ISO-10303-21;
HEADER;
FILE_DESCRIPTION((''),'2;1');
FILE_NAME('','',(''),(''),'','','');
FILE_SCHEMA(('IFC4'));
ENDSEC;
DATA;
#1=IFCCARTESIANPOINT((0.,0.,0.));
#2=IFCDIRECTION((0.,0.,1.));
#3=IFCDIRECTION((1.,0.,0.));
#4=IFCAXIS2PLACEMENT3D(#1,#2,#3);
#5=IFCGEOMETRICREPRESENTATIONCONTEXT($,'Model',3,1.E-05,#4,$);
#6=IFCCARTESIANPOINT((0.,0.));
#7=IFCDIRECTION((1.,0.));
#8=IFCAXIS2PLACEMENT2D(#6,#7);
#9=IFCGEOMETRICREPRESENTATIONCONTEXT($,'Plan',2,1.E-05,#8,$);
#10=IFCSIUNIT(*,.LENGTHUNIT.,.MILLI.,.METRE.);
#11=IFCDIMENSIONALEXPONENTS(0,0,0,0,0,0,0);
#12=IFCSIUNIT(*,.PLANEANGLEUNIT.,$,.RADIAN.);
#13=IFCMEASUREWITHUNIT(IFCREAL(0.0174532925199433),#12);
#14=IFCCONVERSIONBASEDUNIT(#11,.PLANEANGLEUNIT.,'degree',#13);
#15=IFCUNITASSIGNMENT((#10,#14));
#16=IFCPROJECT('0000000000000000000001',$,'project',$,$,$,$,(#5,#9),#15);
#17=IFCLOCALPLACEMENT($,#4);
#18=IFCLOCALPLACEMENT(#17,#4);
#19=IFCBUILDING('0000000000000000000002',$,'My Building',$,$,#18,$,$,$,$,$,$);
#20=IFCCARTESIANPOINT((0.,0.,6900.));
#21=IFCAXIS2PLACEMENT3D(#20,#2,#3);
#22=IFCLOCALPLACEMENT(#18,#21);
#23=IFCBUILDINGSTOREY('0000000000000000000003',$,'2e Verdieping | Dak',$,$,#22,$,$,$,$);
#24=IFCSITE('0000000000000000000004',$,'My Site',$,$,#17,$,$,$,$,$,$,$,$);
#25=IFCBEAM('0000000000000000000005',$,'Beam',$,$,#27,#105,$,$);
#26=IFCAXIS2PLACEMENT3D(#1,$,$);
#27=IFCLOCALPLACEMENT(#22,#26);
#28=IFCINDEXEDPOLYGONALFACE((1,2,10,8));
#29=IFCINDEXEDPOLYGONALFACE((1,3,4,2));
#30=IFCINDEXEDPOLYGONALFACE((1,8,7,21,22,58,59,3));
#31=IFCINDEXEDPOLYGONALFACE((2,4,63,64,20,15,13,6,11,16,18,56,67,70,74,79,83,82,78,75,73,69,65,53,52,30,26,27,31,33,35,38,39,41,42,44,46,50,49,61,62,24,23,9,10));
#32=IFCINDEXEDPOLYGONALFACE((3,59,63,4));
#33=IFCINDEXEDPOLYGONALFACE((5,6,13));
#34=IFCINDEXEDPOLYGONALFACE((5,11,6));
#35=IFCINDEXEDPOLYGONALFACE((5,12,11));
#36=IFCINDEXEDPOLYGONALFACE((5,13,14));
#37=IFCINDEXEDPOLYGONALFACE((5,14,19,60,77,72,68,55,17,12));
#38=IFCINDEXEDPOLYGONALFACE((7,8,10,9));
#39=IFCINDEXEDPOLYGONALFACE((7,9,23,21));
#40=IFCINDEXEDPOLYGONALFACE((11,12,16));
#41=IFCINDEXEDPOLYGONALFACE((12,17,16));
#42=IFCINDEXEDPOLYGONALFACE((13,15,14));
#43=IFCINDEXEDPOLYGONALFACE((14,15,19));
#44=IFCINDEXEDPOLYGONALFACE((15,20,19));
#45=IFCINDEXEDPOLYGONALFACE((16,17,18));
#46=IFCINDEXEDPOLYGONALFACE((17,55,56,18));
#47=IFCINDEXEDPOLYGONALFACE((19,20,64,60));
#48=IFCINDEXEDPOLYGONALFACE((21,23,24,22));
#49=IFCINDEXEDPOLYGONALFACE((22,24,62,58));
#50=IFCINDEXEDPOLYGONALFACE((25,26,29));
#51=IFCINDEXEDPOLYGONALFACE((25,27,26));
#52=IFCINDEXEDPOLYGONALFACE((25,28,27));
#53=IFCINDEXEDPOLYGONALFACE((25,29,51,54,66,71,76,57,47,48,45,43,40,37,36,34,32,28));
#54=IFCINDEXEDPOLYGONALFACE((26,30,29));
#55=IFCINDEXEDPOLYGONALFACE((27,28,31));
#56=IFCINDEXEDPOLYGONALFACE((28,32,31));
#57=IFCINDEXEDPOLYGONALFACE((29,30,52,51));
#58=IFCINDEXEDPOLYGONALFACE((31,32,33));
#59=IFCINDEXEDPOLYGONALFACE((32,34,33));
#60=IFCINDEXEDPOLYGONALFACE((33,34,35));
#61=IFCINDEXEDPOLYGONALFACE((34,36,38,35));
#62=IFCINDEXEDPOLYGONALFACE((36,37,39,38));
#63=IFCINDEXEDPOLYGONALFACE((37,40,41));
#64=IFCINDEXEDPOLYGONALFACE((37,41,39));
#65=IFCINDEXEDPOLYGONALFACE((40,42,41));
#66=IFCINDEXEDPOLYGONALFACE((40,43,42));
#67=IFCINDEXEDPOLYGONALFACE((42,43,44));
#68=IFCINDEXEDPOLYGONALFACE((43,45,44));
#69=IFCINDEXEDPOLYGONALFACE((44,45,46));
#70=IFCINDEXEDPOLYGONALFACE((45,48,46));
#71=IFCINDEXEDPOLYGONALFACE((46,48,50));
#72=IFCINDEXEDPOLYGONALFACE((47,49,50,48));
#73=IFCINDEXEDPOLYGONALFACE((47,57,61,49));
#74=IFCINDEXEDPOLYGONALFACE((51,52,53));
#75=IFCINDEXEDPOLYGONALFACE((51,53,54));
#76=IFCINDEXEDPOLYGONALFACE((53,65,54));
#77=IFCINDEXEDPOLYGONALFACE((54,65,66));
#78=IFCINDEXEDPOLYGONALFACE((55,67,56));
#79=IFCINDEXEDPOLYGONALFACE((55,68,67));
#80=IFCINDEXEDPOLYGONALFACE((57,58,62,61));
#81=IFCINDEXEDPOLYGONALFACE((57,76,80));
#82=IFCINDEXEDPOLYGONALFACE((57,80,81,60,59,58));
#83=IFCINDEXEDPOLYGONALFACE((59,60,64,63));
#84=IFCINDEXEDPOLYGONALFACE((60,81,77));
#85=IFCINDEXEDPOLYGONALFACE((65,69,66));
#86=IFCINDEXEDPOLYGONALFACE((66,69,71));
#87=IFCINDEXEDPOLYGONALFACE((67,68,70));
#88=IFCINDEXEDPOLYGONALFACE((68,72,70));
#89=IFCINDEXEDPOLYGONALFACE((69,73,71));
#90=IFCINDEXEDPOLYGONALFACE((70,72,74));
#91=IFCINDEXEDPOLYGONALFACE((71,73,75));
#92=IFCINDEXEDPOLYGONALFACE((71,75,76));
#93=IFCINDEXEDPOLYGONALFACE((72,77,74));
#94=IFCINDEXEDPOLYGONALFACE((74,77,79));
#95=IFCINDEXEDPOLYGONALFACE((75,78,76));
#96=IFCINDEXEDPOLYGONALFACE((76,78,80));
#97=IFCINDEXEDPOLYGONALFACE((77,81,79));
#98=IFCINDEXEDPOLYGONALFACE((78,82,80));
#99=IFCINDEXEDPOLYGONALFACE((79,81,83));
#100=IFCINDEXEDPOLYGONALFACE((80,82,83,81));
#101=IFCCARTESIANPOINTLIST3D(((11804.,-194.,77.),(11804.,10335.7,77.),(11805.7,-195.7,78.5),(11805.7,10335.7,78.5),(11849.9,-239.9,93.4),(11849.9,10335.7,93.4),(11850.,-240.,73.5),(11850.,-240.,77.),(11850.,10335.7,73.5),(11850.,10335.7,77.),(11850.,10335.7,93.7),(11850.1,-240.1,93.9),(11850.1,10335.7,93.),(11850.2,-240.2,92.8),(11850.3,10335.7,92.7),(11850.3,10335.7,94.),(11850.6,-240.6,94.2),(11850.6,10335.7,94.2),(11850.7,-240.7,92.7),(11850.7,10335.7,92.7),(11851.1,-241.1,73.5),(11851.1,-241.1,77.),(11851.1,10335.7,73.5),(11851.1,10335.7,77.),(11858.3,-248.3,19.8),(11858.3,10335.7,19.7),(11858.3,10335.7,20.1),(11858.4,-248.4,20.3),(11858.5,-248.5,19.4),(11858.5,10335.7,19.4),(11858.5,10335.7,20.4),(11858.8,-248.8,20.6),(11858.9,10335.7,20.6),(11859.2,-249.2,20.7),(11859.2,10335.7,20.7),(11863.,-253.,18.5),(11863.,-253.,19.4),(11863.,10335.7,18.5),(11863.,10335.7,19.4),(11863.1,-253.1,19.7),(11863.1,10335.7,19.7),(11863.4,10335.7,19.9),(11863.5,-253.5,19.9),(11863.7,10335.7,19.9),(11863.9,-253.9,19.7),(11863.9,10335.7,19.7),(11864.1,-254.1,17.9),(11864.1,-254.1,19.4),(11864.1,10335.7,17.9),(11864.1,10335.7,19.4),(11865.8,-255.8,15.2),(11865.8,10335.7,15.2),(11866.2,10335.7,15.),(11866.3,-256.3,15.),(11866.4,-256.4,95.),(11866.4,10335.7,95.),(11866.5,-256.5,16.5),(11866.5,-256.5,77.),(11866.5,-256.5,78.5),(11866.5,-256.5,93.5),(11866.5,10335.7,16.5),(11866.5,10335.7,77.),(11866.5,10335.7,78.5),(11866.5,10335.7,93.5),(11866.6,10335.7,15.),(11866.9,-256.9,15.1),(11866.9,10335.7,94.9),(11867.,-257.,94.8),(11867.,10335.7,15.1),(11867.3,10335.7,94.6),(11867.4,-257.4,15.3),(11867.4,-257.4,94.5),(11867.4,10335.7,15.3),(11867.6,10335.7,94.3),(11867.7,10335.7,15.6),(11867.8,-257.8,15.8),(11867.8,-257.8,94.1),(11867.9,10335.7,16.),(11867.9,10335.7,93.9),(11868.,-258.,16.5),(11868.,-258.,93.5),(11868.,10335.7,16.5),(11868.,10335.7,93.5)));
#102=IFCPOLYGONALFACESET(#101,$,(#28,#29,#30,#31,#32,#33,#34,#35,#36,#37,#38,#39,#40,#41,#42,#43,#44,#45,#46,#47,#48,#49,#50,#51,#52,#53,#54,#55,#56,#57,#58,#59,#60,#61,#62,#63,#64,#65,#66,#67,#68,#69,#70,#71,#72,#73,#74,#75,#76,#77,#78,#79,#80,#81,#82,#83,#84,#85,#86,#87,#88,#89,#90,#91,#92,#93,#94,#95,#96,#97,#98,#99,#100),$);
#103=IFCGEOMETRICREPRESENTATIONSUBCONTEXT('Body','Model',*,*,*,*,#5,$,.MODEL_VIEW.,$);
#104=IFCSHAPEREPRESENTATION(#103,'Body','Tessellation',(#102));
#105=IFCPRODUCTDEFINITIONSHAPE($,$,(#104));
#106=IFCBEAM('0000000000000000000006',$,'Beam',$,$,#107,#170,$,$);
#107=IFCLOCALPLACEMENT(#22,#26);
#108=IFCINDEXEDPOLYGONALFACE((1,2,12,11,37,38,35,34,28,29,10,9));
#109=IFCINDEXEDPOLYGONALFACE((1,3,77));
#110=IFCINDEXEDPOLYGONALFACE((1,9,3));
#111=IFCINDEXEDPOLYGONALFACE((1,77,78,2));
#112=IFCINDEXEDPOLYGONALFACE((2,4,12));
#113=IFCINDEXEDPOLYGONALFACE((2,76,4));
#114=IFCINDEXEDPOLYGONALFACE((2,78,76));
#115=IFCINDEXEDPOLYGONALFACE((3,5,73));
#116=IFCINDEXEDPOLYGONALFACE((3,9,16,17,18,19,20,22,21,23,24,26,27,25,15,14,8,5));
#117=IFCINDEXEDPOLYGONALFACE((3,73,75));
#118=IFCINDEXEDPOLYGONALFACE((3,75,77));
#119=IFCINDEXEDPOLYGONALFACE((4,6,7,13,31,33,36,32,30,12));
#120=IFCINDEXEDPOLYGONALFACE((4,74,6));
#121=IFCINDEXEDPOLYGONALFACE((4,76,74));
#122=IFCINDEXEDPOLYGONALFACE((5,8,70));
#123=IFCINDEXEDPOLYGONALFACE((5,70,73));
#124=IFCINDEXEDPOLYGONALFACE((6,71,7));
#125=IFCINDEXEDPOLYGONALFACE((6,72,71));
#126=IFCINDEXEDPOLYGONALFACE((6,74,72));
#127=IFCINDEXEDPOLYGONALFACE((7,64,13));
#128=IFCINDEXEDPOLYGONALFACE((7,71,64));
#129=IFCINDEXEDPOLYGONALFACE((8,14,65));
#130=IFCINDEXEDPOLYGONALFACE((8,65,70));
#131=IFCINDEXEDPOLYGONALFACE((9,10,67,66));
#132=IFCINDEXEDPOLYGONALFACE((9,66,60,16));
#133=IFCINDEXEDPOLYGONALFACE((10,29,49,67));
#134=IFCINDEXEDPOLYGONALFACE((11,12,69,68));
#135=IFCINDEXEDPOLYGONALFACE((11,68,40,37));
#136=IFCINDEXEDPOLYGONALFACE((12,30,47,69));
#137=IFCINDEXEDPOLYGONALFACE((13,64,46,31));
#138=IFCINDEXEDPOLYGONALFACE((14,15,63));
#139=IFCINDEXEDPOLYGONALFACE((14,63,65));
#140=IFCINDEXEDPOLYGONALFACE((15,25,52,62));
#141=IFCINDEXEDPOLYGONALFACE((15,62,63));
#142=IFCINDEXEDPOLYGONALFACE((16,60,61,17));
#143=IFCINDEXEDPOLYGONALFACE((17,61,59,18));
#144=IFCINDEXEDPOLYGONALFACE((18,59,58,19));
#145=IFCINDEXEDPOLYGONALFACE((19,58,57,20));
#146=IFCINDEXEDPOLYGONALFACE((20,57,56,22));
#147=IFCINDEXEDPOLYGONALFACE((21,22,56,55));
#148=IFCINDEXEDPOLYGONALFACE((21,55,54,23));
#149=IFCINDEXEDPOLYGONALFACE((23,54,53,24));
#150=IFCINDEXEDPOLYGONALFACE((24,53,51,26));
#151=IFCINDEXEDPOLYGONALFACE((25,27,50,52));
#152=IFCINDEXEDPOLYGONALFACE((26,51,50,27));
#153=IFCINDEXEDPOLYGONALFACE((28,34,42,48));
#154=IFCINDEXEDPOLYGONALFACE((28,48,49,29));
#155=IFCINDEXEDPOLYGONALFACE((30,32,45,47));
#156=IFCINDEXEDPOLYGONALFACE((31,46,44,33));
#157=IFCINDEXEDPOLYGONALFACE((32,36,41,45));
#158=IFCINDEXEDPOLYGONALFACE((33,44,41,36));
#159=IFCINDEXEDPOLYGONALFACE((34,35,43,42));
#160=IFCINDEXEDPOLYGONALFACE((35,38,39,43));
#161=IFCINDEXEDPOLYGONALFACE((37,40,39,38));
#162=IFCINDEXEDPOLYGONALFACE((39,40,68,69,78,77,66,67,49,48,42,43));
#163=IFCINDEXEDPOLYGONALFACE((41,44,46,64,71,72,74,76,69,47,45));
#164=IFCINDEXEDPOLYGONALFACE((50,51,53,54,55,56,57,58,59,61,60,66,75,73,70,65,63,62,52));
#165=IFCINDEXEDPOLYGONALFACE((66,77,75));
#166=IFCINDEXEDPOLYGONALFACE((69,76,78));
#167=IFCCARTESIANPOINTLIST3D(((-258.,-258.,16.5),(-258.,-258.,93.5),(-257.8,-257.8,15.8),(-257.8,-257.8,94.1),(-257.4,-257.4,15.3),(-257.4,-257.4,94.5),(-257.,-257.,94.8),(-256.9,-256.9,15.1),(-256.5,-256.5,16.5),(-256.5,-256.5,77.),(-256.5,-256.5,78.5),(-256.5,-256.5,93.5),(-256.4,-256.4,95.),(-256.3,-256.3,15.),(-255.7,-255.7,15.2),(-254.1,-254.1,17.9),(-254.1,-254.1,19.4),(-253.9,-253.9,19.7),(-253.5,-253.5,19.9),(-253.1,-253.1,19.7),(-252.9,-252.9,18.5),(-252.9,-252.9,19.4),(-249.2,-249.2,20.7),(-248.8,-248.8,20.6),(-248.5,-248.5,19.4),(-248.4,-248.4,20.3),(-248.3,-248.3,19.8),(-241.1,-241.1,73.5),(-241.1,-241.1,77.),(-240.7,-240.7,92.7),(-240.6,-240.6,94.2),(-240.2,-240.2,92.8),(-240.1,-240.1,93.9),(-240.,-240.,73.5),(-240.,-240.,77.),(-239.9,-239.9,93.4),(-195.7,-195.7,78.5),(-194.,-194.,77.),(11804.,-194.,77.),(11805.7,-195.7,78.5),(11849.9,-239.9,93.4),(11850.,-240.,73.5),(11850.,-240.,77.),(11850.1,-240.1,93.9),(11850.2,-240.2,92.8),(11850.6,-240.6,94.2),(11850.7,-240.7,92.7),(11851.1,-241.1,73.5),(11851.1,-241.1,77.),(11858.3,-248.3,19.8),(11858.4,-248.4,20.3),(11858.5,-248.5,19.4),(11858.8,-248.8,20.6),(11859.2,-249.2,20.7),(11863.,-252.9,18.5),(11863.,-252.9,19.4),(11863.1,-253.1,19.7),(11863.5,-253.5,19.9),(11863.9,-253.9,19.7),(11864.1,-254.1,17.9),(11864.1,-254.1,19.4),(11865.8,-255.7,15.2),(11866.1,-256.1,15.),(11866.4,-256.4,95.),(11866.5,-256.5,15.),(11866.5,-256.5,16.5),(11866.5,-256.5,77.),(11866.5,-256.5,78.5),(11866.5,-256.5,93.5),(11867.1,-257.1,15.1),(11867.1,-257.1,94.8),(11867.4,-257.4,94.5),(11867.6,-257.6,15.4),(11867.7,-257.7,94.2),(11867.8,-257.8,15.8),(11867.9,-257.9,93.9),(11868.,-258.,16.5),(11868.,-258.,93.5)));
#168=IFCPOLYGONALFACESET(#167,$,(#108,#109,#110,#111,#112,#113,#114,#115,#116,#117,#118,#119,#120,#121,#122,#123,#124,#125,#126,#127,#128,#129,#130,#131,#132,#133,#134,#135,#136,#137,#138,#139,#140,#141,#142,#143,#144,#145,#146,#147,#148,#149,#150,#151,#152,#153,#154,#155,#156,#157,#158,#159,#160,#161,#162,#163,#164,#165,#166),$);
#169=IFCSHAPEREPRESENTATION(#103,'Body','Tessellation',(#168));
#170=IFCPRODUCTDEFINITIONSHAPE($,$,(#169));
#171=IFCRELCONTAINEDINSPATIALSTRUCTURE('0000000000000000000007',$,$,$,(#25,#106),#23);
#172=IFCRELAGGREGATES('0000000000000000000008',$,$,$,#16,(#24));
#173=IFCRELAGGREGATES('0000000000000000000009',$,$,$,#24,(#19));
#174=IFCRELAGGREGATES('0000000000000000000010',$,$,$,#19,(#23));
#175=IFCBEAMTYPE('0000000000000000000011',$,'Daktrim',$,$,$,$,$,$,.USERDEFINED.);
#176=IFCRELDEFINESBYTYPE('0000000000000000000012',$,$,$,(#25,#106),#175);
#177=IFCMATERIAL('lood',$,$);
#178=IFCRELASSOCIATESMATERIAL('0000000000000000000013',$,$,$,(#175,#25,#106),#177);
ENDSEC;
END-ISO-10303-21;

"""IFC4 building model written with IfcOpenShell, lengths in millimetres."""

from ifc_helpers import new_model, entity, si_unit, converted_unit, frame, origin_with_axes, origin_2d_with_axis, place, context, subcontext, project, spatial, line, arc, indexed_curve, outline, extrude, clip, halfspace, material, material_profile, profile_set, profile_usage, type_object, element, save


model = new_model("IFC4")

# Units and contexts
model_context = context("Model", 3, precision=1e-05, world=origin_with_axes())
plan_context = context("Plan", 2, precision=1e-05, world=origin_2d_with_axis())
body_context = subcontext(model_context, "Body", "Model", "MODEL_VIEW")
ifc_project = project(units=[si_unit("LENGTHUNIT", "METRE", prefix="MILLI"), converted_unit("PLANEANGLEUNIT", "degree", entity("IfcReal", 0.0174532925199433), si_unit("PLANEANGLEUNIT", "RADIAN"), dimensions=[0, 0, 0, 0, 0, 0, 0])], contexts=[model_context, plan_context])

# Site, building, storey
site_placement = place(None, origin_with_axes())
site = spatial("IfcSite", under=ifc_project, at=site_placement, Name="My Site")
building_placement = place(site_placement, origin_with_axes())
building = spatial("IfcBuilding", under=site, at=building_placement, Name="My Building")
storey_placement = place(building_placement, frame((0.0, 0.0, 6900.0), z_axis=(0.0, 0.0, 1.0), x_axis=(1.0, 0.0, 0.0)))
storey = spatial("IfcBuildingStorey", under=building, at=storey_placement, Name="2e Verdieping | Dak")

# Beams
ifc_material_1 = material(Name="lood")
ifc_material_profile_1 = material_profile(ifc_material_1, outline(indexed_curve([(12.9, -58.5), (12.9, -57.6), (13.5, -57.1), (14.1, -57.6), (14.1, -59.1), (16.5, -60.5), (16.5, 0.0), (1.1, 0.0), (1.1, -3.5), (0.0, -3.5), (0.0, 0.0), (-46.0, 0.0), (-44.3, 1.5), (16.5, 1.5), (16.5, 16.5), (0.7, 15.7), (-0.1, 16.4), (0.6, 17.2), (16.4, 18.0), (17.6, 17.3), (18.0, 16.5), (18.0, -60.5), (17.2, -61.8), (15.8, -61.8), (8.5, -57.6), (8.4, -56.7), (9.2, -56.3)], segments=[line(10, 9), line(9, 8), line(8, 7), line(7, 6), line(6, 5), line(5, 4), arc(4, 3, 2), line(2, 1), line(1, 27), arc(27, 26, 25), line(25, 24), arc(24, 23, 22), line(22, 21), arc(21, 20, 19), line(19, 18), arc(18, 17, 16), line(16, 15), line(15, 14), line(14, 13), line(13, 12), line(12, 11), line(11, 10)], self_intersect=False)))
ifc_profile_set_1 = profile_set([ifc_material_profile_1], Name="lood")
ifc_profile_usage_1 = profile_usage(ifc_profile_set_1, cardinal=5)
beam_type_1 = type_object("IfcBeamType", Name="Daktrim", PredefinedType="USERDEFINED", material=ifc_profile_set_1)
beam_1_placement = place(storey_placement, frame((11850.0, 10335.7, 77.0), z_axis=(0.0, -1.0, 0.0), x_axis=(1.0, 0.0, 0.0)))
element("IfcBeam", 1, at=beam_1_placement, inside=storey, type_object=beam_type_1, material=ifc_profile_usage_1, Name="Beam", context=body_context, shape_type="Clipping", body=[
    clip(extrude(outline(indexed_curve([(12.9, -58.5), (12.9, -57.6), (13.5, -57.1), (14.1, -57.6), (14.1, -59.1), (16.5, -60.5), (16.5, 0.0), (1.1, 0.0), (1.1, -3.5), (0.0, -3.5), (0.0, 0.0), (-46.0, 0.0), (-44.3, 1.5), (16.5, 1.5), (16.5, 16.5), (0.7, 15.7), (-0.1, 16.4), (0.6, 17.2), (16.4, 18.0), (17.6, 17.3), (18.0, 16.5), (18.0, -60.5), (17.2, -61.8), (15.8, -61.8), (8.5, -57.6), (8.4, -56.7), (9.2, -56.3)], segments=[line(10, 9), line(9, 8), line(8, 7), line(7, 6), line(6, 5), line(5, 4), arc(4, 3, 2), line(2, 1), line(1, 27), arc(27, 26, 25), line(25, 24), arc(24, 23, 22), line(22, 21), arc(21, 20, 19), line(19, 18), arc(18, 17, 16), line(16, 15), line(15, 14), line(14, 13), line(13, 12), line(12, 11), line(11, 10)], self_intersect=False)), origin_with_axes(), (0.0, 0.0, 1.0), 10593.7), halfspace(frame((18.0, -6977.0, 10593.7), z_axis=(-0.707106, 0.0, 0.707107), x_axis=(0.0, 1.0, 0.0)), False)),
])
ifc_profile_usage_2 = profile_usage(ifc_profile_set_1, cardinal=5)
beam_2_placement = place(storey_placement, frame((11868.0, -240.0, 77.0), z_axis=(-1.0, 0.0, 0.0), x_axis=(0.0, -1.0, 0.0)))
element("IfcBeam", 2, at=beam_2_placement, inside=storey, type_object=beam_type_1, material=ifc_profile_usage_2, Name="Beam", context=body_context, shape_type="Clipping", body=[
    clip(clip(extrude(outline(indexed_curve([(12.9, -58.5), (12.9, -57.6), (13.5, -57.1), (14.1, -57.6), (14.1, -59.1), (16.5, -60.5), (16.5, 0.0), (1.1, 0.0), (1.1, -3.5), (0.0, -3.5), (0.0, 0.0), (-46.0, 0.0), (-44.3, 1.5), (16.5, 1.5), (16.5, 16.5), (0.7, 15.7), (-0.1, 16.4), (0.6, 17.2), (16.4, 18.0), (17.6, 17.3), (18.0, 16.5), (18.0, -60.5), (17.2, -61.8), (15.8, -61.8), (8.5, -57.6), (8.4, -56.7), (9.2, -56.3)], segments=[line(10, 9), line(9, 8), line(8, 7), line(7, 6), line(6, 5), line(5, 4), arc(4, 3, 2), line(2, 1), line(1, 27), arc(27, 26, 25), line(25, 24), arc(24, 23, 22), line(22, 21), arc(21, 20, 19), line(19, 18), arc(18, 17, 16), line(16, 15), line(15, 14), line(14, 13), line(13, 12), line(12, 11), line(11, 10)], self_intersect=False)), origin_with_axes(), (0.0, 0.0, 1.0), 12126.0), halfspace(frame((18.0, -6977.0, 0.0), z_axis=(-0.707107, 0.0, -0.707106), x_axis=(0.0, 1.0, 0.0)), False)), halfspace(frame((18.0, -6977.0, 12126.0), z_axis=(-0.707107, 0.0, 0.707107), x_axis=(0.0, 1.0, 0.0)), False)),
])

save(model, "model.ifc")
